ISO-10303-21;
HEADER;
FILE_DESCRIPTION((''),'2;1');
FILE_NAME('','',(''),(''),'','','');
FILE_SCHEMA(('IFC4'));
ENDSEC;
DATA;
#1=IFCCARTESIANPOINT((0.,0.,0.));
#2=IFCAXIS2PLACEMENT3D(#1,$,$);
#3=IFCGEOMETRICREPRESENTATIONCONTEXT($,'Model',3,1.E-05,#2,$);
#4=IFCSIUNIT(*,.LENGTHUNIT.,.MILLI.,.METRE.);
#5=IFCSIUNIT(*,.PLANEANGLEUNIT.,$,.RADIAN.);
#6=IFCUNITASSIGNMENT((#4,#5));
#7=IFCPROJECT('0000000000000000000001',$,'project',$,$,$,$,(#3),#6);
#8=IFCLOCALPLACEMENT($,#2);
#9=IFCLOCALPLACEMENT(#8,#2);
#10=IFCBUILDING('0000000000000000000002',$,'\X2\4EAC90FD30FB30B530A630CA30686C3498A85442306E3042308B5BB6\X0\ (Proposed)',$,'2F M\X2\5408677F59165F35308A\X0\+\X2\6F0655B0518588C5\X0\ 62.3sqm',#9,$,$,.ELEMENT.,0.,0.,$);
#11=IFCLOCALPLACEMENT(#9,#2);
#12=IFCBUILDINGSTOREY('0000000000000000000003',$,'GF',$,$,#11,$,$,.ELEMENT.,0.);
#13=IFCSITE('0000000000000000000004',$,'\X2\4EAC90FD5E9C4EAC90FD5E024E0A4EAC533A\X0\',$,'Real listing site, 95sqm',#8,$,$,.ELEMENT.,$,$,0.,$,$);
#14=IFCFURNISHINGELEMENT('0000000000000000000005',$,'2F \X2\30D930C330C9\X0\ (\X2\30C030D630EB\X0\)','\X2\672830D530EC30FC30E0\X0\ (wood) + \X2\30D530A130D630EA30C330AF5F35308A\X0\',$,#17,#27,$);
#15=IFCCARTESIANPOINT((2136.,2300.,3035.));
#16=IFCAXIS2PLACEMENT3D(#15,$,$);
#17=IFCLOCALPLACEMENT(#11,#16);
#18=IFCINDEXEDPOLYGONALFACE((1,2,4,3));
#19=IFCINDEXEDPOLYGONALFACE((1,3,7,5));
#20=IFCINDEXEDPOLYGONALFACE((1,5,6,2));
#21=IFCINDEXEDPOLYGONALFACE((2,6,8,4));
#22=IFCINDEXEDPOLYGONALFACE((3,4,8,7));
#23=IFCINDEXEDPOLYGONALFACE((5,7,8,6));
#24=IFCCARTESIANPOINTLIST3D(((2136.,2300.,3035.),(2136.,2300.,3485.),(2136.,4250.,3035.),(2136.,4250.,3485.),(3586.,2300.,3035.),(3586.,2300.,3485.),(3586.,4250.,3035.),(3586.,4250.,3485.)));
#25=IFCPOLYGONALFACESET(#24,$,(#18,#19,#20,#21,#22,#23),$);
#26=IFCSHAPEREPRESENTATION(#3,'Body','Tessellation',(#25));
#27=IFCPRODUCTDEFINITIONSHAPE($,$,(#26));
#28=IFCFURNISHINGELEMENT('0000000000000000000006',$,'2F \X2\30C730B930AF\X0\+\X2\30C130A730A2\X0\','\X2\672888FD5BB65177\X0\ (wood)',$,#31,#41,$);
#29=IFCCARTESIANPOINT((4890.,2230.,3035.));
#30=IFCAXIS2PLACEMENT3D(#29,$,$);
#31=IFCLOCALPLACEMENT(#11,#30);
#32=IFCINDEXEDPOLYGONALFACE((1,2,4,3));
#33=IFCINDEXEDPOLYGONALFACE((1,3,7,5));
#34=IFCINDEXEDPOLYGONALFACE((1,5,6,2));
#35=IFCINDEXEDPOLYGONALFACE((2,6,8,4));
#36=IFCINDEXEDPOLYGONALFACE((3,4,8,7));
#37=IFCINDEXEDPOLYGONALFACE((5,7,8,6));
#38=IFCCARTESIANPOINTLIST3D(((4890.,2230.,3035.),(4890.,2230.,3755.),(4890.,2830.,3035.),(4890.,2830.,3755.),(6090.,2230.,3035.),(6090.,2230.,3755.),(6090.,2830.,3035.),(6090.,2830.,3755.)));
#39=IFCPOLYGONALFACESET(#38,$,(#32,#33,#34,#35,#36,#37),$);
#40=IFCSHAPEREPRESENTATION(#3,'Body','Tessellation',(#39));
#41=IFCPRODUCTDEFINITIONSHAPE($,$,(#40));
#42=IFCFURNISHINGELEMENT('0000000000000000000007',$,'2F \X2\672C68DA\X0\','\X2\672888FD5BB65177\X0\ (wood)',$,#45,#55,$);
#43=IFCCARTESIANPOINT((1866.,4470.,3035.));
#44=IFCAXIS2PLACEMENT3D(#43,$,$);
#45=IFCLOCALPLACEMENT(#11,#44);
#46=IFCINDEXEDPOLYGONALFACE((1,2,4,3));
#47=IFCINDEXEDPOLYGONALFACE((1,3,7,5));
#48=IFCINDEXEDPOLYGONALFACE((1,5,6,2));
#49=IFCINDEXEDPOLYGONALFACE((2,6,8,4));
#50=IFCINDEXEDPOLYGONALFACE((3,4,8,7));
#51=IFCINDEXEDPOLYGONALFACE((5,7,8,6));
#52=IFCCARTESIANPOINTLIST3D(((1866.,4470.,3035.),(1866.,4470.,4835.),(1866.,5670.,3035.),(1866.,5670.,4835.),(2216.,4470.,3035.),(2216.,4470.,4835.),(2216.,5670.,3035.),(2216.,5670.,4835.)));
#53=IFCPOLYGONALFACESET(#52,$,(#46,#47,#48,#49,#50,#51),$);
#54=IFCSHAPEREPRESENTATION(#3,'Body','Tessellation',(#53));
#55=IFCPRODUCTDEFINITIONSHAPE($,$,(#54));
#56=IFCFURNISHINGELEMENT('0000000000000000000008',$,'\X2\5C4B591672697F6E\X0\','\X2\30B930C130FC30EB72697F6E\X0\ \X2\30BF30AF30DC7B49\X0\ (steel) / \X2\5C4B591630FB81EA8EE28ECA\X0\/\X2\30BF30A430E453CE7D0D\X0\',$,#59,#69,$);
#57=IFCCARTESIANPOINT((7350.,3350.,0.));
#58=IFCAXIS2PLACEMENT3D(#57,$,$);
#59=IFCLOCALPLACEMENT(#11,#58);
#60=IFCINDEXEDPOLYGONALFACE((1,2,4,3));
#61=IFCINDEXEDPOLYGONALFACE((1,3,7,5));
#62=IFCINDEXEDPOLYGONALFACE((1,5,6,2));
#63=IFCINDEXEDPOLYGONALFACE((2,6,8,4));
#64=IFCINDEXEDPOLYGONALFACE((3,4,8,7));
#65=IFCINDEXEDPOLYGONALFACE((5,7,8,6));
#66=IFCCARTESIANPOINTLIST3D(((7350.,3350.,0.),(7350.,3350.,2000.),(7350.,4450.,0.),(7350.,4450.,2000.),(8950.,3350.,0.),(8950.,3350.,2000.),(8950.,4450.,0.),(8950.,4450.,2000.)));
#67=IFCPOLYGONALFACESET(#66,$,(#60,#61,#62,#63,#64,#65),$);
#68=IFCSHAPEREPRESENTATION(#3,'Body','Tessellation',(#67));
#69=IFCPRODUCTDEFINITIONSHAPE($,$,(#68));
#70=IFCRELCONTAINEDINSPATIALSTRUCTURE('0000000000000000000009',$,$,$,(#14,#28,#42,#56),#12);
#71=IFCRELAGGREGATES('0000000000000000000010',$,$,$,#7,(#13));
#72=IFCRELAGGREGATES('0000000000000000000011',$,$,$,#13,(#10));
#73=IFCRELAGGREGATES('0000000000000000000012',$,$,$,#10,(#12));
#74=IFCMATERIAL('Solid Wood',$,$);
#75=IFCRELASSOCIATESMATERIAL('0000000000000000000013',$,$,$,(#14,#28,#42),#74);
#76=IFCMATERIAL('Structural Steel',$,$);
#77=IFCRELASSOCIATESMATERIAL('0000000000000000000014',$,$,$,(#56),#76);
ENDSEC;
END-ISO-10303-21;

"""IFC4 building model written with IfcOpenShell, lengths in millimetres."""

from ifc_helpers import new_model, si_unit, frame, frame_2d, origin, place, context, project, spatial, rectangle, extrude, material, element, save


model = new_model("IFC4")

# Units and contexts
model_context = context("Model", 3, precision=1e-05, world=origin())
ifc_project = project(units=[si_unit("LENGTHUNIT", "METRE", prefix="MILLI"), si_unit("PLANEANGLEUNIT", "RADIAN")], contexts=[model_context])

# Site, building, storey
site_placement = place(None, origin())
site = spatial("IfcSite", under=ifc_project, at=site_placement, Name="京都府京都市上京区", ObjectType="Real listing site, 95sqm", CompositionType="ELEMENT", RefElevation=0.0)
building_placement = place(site_placement, origin())
building = spatial("IfcBuilding", under=site, at=building_placement, Name="京都・サウナと水風呂のある家 (Proposed)", ObjectType="2F M合板外張り+漆喰内装 62.3sqm", CompositionType="ELEMENT", ElevationOfRefHeight=0.0, ElevationOfTerrain=0.0)
storey_placement = place(building_placement, origin())
storey = spatial("IfcBuildingStorey", under=building, at=storey_placement, Name="GF", CompositionType="ELEMENT", Elevation=0.0)

# Shared definitions
ifc_material_1 = material(Name="Solid Wood")

# Shared definitions
ifc_material_2 = material(Name="Structural Steel")

# Furnishing elements
furnishing_1_placement = place(storey_placement, frame((2136.0, 2300.0, 3035.0)))
element("IfcFurnishingElement", 1, at=furnishing_1_placement, inside=storey, material=ifc_material_1, Name="2F ベッド (ダブル)", Description="木フレーム (wood) + ファブリック張り", context=model_context, shape_type="SweptSolid", body=[
    extrude(rectangle(XDim=1450.0, YDim=1950.0, at=frame_2d((725.0, 975.0))), frame((2136.0, 2300.0, 3035.0)), (0.0, 0.0, 1.0), 450.0),
])
furnishing_2_placement = place(storey_placement, frame((4890.0, 2230.0, 3035.0)))
element("IfcFurnishingElement", 2, at=furnishing_2_placement, inside=storey, material=ifc_material_1, Name="2F デスク+チェア", Description="木製家具 (wood)", context=model_context, shape_type="SweptSolid", body=[
    extrude(rectangle(XDim=1200.0, YDim=600.0, at=frame_2d((600.0, 300.0))), frame((4890.0, 2230.0, 3035.0)), (0.0, 0.0, 1.0), 720.0),
])
furnishing_3_placement = place(storey_placement, frame((1866.0, 4470.0, 3035.0)))
element("IfcFurnishingElement", 3, at=furnishing_3_placement, inside=storey, material=ifc_material_1, Name="2F 本棚", Description="木製家具 (wood)", context=model_context, shape_type="SweptSolid", body=[
    extrude(rectangle(XDim=350.0, YDim=1200.0, at=frame_2d((175.0, 600.0))), frame((1866.0, 4470.0, 3035.0)), (0.0, 0.0, 1.0), 1800.0),
])
furnishing_4_placement = place(storey_placement, frame((7350.0, 3350.0, 0.0)))
element("IfcFurnishingElement", 4, at=furnishing_4_placement, inside=storey, material=ifc_material_2, Name="屋外物置", Description="スチール物置 タクボ等 (steel) / 屋外・自転車/タイヤ収納", context=model_context, shape_type="SweptSolid", body=[
    extrude(rectangle(XDim=1600.0, YDim=1100.0, at=frame_2d((800.0, 550.0))), frame((7350.0, 3350.0, 0.0)), (0.0, 0.0, 1.0), 2000.0),
])

save(model, "model.ifc")
